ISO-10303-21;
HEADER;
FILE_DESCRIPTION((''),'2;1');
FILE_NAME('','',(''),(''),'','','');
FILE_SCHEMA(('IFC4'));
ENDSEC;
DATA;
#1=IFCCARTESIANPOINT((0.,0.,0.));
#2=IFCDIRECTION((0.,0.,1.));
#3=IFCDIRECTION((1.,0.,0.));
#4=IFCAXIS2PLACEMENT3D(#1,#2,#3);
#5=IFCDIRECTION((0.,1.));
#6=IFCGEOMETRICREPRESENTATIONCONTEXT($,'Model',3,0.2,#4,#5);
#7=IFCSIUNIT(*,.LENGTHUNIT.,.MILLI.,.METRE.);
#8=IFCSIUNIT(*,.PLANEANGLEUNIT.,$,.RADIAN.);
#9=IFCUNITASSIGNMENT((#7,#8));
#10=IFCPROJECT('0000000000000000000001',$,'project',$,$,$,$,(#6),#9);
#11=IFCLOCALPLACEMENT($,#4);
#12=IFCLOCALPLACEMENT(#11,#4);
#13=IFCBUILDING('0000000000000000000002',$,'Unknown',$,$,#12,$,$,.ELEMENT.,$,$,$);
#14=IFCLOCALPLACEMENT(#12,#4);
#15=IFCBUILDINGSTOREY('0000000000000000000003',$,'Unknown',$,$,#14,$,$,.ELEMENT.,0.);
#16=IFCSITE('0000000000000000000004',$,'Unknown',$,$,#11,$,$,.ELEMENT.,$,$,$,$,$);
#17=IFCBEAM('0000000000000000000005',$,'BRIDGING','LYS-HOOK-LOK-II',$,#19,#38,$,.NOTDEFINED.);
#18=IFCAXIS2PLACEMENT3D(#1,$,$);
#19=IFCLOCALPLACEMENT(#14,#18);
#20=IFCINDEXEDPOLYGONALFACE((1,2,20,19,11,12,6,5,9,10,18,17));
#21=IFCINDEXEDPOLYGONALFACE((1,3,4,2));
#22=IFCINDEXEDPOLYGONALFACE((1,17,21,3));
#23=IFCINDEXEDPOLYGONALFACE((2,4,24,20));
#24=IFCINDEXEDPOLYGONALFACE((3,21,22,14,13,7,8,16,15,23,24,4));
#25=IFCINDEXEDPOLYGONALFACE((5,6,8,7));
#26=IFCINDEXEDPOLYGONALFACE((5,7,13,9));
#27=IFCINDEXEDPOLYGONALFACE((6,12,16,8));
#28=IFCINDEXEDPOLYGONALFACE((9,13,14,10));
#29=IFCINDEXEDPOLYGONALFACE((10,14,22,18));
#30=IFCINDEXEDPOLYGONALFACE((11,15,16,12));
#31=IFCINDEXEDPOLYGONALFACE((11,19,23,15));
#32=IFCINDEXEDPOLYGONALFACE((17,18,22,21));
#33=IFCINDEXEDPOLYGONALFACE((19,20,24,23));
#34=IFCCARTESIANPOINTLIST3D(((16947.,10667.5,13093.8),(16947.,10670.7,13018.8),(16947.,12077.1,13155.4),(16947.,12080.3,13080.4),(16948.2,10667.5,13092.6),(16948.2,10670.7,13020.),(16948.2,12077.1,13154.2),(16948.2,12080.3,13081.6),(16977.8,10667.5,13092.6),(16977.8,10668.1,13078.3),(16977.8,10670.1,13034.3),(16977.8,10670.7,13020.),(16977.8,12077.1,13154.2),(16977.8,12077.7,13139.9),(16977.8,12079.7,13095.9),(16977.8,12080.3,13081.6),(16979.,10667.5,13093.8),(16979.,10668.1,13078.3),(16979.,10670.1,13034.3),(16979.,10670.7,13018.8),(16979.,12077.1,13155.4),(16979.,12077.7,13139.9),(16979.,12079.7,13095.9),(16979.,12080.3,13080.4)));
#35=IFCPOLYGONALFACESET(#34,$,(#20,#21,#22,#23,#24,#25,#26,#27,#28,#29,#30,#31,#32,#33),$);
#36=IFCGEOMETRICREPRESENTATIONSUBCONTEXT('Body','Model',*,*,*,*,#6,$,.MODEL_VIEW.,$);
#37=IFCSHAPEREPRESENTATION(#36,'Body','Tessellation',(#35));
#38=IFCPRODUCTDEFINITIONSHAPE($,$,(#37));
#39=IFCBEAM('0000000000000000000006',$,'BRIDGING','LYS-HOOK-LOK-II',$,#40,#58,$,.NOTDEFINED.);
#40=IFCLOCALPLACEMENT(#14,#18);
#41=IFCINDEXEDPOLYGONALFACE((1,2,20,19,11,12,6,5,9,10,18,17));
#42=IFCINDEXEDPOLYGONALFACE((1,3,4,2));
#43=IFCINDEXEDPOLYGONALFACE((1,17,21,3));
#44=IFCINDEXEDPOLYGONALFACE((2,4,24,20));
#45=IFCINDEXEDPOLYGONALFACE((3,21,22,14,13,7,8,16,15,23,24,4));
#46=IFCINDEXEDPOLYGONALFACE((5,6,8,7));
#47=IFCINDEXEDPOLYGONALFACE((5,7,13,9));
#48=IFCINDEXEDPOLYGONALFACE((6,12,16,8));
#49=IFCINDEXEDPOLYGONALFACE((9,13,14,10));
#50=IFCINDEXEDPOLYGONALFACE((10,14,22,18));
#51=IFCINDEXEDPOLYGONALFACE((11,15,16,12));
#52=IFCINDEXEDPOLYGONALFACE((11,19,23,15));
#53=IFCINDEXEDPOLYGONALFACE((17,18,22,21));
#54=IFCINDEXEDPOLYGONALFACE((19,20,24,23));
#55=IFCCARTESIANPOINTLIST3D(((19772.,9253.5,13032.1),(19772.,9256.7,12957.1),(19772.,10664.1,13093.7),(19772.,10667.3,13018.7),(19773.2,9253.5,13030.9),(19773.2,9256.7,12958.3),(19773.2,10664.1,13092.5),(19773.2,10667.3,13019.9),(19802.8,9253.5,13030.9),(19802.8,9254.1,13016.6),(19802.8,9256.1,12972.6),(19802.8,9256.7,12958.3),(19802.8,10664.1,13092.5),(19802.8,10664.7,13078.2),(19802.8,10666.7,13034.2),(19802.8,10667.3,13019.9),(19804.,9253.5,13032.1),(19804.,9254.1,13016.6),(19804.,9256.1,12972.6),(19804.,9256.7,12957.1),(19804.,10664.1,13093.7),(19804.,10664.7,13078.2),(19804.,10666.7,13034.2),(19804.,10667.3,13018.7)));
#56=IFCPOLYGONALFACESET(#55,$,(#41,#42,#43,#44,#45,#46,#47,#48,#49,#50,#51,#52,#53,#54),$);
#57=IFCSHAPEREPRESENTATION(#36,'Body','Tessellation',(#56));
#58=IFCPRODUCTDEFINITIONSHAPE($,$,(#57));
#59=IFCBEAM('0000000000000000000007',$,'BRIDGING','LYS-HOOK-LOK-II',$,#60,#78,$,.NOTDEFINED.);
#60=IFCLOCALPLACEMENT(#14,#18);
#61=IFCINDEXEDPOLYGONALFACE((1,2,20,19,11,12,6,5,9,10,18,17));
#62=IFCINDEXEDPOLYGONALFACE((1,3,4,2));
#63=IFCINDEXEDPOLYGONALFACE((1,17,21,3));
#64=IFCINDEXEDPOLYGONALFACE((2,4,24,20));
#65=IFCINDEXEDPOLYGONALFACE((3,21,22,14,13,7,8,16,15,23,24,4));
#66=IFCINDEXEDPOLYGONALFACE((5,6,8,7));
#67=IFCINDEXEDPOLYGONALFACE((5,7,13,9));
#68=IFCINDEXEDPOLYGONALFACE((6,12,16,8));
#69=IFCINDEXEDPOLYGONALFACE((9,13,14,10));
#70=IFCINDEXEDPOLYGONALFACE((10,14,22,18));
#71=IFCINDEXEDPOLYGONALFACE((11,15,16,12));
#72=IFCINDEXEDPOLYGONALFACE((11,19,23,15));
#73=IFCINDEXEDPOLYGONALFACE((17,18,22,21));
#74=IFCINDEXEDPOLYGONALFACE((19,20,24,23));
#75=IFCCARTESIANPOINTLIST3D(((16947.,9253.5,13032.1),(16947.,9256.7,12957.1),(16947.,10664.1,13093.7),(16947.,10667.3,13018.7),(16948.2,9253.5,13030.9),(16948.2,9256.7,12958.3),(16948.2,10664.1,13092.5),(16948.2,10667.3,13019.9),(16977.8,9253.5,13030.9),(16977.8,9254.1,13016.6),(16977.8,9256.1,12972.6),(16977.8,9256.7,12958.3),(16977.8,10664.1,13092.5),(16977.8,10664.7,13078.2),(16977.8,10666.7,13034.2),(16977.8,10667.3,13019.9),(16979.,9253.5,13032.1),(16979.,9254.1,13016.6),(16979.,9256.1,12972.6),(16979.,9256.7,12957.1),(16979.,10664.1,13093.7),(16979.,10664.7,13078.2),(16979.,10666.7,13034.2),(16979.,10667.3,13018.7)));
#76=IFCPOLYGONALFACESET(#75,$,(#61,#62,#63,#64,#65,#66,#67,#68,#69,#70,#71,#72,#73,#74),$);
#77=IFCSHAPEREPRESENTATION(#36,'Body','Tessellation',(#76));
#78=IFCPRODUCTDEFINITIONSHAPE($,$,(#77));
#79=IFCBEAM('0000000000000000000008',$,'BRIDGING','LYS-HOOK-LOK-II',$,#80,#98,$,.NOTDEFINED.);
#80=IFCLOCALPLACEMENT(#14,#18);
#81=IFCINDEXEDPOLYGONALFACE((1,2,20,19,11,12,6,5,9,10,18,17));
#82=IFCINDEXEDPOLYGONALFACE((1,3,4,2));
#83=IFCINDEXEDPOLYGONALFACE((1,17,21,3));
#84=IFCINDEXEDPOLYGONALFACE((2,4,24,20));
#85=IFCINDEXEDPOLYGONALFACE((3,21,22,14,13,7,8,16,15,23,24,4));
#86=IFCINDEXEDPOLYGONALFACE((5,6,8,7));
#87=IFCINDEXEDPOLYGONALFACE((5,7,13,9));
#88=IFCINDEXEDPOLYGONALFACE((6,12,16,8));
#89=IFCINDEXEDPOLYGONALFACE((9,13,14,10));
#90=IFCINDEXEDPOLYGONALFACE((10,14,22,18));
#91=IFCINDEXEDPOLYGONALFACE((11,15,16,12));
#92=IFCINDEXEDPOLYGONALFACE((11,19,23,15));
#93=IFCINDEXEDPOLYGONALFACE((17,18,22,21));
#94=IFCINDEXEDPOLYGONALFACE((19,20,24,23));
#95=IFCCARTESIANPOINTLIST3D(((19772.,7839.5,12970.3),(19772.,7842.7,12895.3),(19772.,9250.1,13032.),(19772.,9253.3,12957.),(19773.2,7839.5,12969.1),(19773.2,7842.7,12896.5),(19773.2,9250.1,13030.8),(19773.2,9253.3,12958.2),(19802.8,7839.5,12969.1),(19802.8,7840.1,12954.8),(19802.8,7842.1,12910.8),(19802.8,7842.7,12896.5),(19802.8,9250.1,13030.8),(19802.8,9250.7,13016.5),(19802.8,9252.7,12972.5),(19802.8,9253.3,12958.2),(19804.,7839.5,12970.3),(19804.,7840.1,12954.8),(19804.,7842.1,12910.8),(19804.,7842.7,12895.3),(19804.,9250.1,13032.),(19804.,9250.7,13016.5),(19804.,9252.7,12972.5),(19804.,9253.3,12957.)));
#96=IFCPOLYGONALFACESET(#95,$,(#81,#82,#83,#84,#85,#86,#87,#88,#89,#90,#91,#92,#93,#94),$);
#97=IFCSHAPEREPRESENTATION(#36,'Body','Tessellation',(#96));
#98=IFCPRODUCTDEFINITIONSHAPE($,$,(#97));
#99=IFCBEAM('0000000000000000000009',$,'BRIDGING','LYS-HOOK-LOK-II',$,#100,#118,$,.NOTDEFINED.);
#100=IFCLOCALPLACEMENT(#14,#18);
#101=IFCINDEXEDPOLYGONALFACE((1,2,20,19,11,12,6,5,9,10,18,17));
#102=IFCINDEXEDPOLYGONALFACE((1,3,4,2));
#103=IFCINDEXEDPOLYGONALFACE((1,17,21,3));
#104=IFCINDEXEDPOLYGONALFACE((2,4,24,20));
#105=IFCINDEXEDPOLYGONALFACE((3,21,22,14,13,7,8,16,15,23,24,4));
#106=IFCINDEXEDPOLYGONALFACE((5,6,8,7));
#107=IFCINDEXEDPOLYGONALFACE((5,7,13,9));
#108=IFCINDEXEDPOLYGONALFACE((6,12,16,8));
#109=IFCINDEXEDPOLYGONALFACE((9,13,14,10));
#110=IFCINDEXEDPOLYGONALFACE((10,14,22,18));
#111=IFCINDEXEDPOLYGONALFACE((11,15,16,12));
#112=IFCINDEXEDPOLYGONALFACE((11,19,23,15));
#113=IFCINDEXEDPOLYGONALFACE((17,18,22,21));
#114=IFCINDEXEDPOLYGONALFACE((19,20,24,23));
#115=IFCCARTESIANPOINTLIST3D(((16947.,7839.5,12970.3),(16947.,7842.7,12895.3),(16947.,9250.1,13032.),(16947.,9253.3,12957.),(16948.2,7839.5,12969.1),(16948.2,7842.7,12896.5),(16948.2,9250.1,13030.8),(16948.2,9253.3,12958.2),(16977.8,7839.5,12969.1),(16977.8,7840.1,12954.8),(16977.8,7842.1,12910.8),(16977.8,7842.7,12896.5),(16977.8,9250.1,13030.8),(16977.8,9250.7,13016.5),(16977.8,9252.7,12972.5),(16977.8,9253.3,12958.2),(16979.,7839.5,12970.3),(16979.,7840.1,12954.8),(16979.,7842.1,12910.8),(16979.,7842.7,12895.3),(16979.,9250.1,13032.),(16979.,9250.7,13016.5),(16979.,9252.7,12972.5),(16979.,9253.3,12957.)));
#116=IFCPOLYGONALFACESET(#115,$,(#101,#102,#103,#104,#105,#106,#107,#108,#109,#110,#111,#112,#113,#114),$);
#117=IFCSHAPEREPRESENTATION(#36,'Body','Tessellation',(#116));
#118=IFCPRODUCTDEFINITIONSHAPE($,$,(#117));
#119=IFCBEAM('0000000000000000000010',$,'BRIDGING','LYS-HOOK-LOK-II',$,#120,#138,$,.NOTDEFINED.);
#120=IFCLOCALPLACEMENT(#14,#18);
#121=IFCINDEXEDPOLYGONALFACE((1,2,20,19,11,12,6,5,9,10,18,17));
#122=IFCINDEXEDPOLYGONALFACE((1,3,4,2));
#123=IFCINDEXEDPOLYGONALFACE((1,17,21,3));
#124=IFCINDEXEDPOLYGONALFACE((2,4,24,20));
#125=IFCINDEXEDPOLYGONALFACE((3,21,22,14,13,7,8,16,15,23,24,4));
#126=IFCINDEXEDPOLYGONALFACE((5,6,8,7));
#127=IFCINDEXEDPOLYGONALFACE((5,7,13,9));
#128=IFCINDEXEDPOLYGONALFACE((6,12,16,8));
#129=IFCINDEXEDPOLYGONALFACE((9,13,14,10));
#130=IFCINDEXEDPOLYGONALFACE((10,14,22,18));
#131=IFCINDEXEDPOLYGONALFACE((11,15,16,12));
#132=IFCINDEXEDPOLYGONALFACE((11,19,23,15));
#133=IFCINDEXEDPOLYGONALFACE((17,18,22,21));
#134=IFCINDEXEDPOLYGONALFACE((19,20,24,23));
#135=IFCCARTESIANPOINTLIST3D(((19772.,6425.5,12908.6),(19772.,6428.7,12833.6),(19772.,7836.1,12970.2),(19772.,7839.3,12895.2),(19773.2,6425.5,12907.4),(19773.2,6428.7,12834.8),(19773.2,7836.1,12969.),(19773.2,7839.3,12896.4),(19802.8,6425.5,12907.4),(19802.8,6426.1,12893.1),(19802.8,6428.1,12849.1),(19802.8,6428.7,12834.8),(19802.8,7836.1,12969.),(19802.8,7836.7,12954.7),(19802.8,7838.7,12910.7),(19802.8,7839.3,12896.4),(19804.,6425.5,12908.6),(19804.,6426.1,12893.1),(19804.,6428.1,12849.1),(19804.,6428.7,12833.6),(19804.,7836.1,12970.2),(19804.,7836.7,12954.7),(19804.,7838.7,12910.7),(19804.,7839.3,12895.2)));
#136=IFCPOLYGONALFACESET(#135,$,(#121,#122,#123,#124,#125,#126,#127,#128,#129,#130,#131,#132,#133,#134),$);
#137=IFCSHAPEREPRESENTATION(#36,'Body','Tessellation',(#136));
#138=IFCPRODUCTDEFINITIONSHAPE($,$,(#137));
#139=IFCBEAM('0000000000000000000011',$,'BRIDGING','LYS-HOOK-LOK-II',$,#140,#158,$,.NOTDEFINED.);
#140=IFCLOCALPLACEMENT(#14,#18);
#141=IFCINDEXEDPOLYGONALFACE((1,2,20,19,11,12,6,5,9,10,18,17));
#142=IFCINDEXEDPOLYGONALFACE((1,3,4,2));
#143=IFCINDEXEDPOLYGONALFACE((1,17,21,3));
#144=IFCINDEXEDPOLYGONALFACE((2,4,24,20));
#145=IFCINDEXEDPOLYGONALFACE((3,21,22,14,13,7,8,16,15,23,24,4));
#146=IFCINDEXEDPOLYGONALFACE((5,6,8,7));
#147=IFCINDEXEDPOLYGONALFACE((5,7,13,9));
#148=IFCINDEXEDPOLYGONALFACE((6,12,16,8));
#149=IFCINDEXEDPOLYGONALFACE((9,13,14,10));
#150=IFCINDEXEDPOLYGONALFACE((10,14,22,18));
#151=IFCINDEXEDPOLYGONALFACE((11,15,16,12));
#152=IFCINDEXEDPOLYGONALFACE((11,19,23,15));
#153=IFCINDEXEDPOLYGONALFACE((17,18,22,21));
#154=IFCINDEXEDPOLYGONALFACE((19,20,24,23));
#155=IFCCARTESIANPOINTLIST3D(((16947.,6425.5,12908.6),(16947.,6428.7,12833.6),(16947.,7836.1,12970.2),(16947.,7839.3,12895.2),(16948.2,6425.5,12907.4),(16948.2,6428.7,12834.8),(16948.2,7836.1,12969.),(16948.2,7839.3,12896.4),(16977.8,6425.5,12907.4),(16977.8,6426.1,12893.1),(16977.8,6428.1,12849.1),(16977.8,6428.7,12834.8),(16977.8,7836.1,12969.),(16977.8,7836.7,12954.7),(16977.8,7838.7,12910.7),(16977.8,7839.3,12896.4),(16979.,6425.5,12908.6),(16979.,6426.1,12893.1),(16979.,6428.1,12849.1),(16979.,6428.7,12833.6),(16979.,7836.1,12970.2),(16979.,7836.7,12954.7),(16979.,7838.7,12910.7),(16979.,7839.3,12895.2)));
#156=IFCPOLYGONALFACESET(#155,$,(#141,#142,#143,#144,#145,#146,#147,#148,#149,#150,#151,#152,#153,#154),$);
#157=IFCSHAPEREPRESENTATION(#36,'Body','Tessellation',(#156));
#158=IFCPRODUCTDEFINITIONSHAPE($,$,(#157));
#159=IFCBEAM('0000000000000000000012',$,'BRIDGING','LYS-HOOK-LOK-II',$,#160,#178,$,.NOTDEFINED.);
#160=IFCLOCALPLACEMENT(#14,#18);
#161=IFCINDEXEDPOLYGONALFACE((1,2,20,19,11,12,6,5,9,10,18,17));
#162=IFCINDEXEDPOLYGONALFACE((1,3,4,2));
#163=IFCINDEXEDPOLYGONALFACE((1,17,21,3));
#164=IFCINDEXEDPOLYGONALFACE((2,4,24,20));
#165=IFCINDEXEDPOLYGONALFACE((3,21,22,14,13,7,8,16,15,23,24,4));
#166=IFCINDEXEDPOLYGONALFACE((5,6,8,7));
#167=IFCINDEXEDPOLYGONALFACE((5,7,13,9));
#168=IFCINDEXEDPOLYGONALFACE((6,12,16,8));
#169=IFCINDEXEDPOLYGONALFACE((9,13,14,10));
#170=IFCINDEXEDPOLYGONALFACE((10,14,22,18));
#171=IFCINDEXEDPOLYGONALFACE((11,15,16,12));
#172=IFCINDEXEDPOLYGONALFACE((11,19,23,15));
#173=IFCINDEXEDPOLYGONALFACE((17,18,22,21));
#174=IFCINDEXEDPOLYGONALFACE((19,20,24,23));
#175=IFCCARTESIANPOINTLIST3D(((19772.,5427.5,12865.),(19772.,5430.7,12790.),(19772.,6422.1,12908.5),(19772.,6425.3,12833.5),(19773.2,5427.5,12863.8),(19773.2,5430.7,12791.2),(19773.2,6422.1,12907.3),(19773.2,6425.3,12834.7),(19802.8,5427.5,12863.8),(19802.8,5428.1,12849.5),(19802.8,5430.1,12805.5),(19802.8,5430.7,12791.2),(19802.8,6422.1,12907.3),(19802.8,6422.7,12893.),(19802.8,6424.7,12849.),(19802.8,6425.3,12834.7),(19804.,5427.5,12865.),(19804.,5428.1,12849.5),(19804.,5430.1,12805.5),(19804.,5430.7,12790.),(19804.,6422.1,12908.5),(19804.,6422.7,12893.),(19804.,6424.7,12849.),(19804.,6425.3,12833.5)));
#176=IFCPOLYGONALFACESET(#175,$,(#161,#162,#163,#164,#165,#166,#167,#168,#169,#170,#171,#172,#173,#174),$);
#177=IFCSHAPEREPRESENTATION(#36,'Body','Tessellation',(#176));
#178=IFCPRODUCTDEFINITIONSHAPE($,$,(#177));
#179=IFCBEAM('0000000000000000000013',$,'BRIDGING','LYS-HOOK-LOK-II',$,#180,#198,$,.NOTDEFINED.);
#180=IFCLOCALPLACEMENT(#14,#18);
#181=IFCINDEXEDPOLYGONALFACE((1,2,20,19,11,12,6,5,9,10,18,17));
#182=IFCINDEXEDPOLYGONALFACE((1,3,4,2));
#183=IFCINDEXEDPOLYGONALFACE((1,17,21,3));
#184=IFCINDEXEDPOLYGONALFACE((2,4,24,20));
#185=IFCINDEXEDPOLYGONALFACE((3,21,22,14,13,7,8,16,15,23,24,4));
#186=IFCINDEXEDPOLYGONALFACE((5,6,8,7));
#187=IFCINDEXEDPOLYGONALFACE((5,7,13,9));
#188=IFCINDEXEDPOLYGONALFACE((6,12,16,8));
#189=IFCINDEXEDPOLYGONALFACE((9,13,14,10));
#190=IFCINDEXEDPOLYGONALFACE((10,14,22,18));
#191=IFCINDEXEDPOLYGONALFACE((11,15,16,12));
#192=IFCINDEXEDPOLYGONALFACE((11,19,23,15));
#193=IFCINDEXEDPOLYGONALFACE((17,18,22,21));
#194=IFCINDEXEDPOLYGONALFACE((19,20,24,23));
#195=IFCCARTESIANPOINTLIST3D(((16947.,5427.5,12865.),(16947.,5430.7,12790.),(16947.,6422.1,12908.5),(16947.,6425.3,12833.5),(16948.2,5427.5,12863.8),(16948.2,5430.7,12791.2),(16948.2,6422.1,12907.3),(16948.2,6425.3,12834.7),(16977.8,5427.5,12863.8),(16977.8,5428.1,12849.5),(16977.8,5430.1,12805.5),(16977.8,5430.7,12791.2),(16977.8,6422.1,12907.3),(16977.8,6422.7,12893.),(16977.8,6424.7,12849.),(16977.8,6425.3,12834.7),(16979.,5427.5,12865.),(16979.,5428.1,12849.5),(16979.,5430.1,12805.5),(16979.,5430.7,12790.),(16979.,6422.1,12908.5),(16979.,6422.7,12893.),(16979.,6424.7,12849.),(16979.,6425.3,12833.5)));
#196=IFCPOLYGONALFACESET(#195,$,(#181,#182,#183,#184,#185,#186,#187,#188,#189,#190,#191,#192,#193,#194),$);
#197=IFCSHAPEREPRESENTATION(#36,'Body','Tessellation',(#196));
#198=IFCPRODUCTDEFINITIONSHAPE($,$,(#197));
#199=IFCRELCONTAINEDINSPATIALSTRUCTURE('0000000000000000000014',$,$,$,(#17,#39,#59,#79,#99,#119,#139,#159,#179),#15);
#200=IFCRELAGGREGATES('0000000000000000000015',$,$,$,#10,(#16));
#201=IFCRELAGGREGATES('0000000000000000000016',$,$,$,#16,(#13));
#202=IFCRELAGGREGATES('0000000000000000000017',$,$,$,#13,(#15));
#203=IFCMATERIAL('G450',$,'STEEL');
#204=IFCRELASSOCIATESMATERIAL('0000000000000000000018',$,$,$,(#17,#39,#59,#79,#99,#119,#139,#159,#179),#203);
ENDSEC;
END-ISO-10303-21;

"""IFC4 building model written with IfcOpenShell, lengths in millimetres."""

from ifc_helpers import new_model, si_unit, direction, frame, origin_with_axes, place, context, subcontext, project, spatial, line, indexed_curve, outline, extrude, material, element, save


model = new_model("IFC4")

# Units and contexts
model_context = context("Model", 3, precision=0.2, world=origin_with_axes(), true_north=direction((0.0, 1.0)))
body_context = subcontext(model_context, "Body", "Model", "MODEL_VIEW")
ifc_project = project(units=[si_unit("LENGTHUNIT", "METRE", prefix="MILLI"), si_unit("PLANEANGLEUNIT", "RADIAN")], contexts=[model_context])

# Site, building, storey
site_placement = place(None, origin_with_axes())
site = spatial("IfcSite", under=ifc_project, at=site_placement, Name="Unknown", CompositionType="ELEMENT")
building_placement = place(site_placement, origin_with_axes())
building = spatial("IfcBuilding", under=site, at=building_placement, Name="Unknown", CompositionType="ELEMENT")
storey_placement = place(building_placement, origin_with_axes())
storey = spatial("IfcBuildingStorey", under=building, at=storey_placement, Name="Unknown", CompositionType="ELEMENT", Elevation=0.0)

# Beams
ifc_material_1 = material(Name="G450", Category="STEEL")
for number, where, z_axis, x_axis, name in (
    (1, (16963.0, 10669.1, 13056.3), (1.0, 0.0, 0.0), (0.0, 0.999047, 0.043659), "BRIDGING"),
):
    element("IfcBeam", number, at=place(storey_placement, frame(where, z_axis=z_axis, x_axis=x_axis)), inside=storey, material=ifc_material_1, Name=name, Description="LYS-HOOK-LOK-II", PredefinedType="NOTDEFINED", context=body_context, shape_type="SolidModel", body=[
        extrude(outline(indexed_curve([(16.0, -37.5), (16.0, -22.0), (14.8, -22.0), (14.8, -36.3), (-14.8, -36.3), (-14.8, 36.3), (14.8, 36.3), (14.8, 22.0), (16.0, 22.0), (16.0, 37.5), (-16.0, 37.5), (-16.0, -37.5)], segments=[line(1, 2, 3, 4, 5, 6, 7, 8, 9, 10, 11, 12, 1)])), frame((0.0, 0.0, 0.0), z_axis=(-1.0, 0.0, 0.0), x_axis=(0.0, 0.0, 1.0)), (0.0, 0.0, -1.0), 1410.9),
    ])
for number, where, z_axis, x_axis, name in (
    (2, (19788.0, 9255.1, 12994.6), (1.0, 0.0, 0.0), (0.0, 0.999048, 0.043628), "BRIDGING"),
    (3, (16963.0, 9255.1, 12994.6), (1.0, 0.0, 0.0), (0.0, 0.999048, 0.043628), "BRIDGING"),
):
    element("IfcBeam", number, at=place(storey_placement, frame(where, z_axis=z_axis, x_axis=x_axis)), inside=storey, material=ifc_material_1, Name=name, Description="LYS-HOOK-LOK-II", PredefinedType="NOTDEFINED", context=body_context, shape_type="SolidModel", body=[
        extrude(outline(indexed_curve([(16.0, -37.5), (16.0, -22.0), (14.8, -22.0), (14.8, -36.3), (-14.8, -36.3), (-14.8, 36.3), (14.8, 36.3), (14.8, 22.0), (16.0, 22.0), (16.0, 37.5), (-16.0, 37.5), (-16.0, -37.5)], segments=[line(1, 2, 3, 4, 5, 6, 7, 8, 9, 10, 11, 12, 1)])), frame((0.0, 0.0, 0.0), z_axis=(-1.0, 0.0, 0.0), x_axis=(0.0, 0.0, 1.0)), (0.0, 0.0, -1.0), 1411.9),
    ])
for number, where, z_axis, x_axis, name in (
    (4, (19788.0, 7841.1, 12932.8), (1.0, 0.0, 0.0), (0.0, 0.999045, 0.043698), "BRIDGING"),
    (5, (16963.0, 7841.1, 12932.8), (1.0, 0.0, 0.0), (0.0, 0.999045, 0.043698), "BRIDGING"),
):
    element("IfcBeam", number, at=place(storey_placement, frame(where, z_axis=z_axis, x_axis=x_axis)), inside=storey, material=ifc_material_1, Name=name, Description="LYS-HOOK-LOK-II", PredefinedType="NOTDEFINED", context=body_context, shape_type="SolidModel", body=[
        extrude(outline(indexed_curve([(16.0, -37.5), (16.0, -22.0), (14.8, -22.0), (14.8, -36.3), (-14.8, -36.3), (-14.8, 36.3), (14.8, 36.3), (14.8, 22.0), (16.0, 22.0), (16.0, 37.5), (-16.0, 37.5), (-16.0, -37.5)], segments=[line(1, 2, 3, 4, 5, 6, 7, 8, 9, 10, 11, 12, 1)])), frame((0.0, 0.0, 0.0), z_axis=(-1.0, 0.0, 0.0), x_axis=(0.0, 0.0, 1.0)), (0.0, 0.0, -1.0), 1411.9),
    ])
for number, where, z_axis, x_axis, name in (
    (6, (19788.0, 6427.1, 12871.1), (1.0, 0.0, 0.0), (0.0, 0.999048, 0.043628), "BRIDGING"),
    (7, (16963.0, 6427.1, 12871.1), (1.0, 0.0, 0.0), (0.0, 0.999048, 0.043628), "BRIDGING"),
):
    element("IfcBeam", number, at=place(storey_placement, frame(where, z_axis=z_axis, x_axis=x_axis)), inside=storey, material=ifc_material_1, Name=name, Description="LYS-HOOK-LOK-II", PredefinedType="NOTDEFINED", context=body_context, shape_type="SolidModel", body=[
        extrude(outline(indexed_curve([(16.0, -37.5), (16.0, -22.0), (14.8, -22.0), (14.8, -36.3), (-14.8, -36.3), (-14.8, 36.3), (14.8, 36.3), (14.8, 22.0), (16.0, 22.0), (16.0, 37.5), (-16.0, 37.5), (-16.0, -37.5)], segments=[line(1, 2, 3, 4, 5, 6, 7, 8, 9, 10, 11, 12, 1)])), frame((0.0, 0.0, 0.0), z_axis=(-1.0, 0.0, 0.0), x_axis=(0.0, 0.0, 1.0)), (0.0, 0.0, -1.0), 1411.9),
    ])
for number, where, z_axis, x_axis, name in (
    (8, (19788.0, 5429.1, 12827.5), (1.0, 0.0, 0.0), (0.0, 0.999045, 0.043694), "BRIDGING"),
    (9, (16963.0, 5429.1, 12827.5), (1.0, 0.0, 0.0), (0.0, 0.999045, 0.043694), "BRIDGING"),
):
    element("IfcBeam", number, at=place(storey_placement, frame(where, z_axis=z_axis, x_axis=x_axis)), inside=storey, material=ifc_material_1, Name=name, Description="LYS-HOOK-LOK-II", PredefinedType="NOTDEFINED", context=body_context, shape_type="SolidModel", body=[
        extrude(outline(indexed_curve([(16.0, -37.5), (16.0, -22.0), (14.8, -22.0), (14.8, -36.3), (-14.8, -36.3), (-14.8, 36.3), (14.8, 36.3), (14.8, 22.0), (16.0, 22.0), (16.0, 37.5), (-16.0, 37.5), (-16.0, -37.5)], segments=[line(1, 2, 3, 4, 5, 6, 7, 8, 9, 10, 11, 12, 1)])), frame((0.0, 0.0, 0.0), z_axis=(-1.0, 0.0, 0.0), x_axis=(0.0, 0.0, 1.0)), (0.0, 0.0, -1.0), 995.6),
    ])

save(model, "model.ifc")
